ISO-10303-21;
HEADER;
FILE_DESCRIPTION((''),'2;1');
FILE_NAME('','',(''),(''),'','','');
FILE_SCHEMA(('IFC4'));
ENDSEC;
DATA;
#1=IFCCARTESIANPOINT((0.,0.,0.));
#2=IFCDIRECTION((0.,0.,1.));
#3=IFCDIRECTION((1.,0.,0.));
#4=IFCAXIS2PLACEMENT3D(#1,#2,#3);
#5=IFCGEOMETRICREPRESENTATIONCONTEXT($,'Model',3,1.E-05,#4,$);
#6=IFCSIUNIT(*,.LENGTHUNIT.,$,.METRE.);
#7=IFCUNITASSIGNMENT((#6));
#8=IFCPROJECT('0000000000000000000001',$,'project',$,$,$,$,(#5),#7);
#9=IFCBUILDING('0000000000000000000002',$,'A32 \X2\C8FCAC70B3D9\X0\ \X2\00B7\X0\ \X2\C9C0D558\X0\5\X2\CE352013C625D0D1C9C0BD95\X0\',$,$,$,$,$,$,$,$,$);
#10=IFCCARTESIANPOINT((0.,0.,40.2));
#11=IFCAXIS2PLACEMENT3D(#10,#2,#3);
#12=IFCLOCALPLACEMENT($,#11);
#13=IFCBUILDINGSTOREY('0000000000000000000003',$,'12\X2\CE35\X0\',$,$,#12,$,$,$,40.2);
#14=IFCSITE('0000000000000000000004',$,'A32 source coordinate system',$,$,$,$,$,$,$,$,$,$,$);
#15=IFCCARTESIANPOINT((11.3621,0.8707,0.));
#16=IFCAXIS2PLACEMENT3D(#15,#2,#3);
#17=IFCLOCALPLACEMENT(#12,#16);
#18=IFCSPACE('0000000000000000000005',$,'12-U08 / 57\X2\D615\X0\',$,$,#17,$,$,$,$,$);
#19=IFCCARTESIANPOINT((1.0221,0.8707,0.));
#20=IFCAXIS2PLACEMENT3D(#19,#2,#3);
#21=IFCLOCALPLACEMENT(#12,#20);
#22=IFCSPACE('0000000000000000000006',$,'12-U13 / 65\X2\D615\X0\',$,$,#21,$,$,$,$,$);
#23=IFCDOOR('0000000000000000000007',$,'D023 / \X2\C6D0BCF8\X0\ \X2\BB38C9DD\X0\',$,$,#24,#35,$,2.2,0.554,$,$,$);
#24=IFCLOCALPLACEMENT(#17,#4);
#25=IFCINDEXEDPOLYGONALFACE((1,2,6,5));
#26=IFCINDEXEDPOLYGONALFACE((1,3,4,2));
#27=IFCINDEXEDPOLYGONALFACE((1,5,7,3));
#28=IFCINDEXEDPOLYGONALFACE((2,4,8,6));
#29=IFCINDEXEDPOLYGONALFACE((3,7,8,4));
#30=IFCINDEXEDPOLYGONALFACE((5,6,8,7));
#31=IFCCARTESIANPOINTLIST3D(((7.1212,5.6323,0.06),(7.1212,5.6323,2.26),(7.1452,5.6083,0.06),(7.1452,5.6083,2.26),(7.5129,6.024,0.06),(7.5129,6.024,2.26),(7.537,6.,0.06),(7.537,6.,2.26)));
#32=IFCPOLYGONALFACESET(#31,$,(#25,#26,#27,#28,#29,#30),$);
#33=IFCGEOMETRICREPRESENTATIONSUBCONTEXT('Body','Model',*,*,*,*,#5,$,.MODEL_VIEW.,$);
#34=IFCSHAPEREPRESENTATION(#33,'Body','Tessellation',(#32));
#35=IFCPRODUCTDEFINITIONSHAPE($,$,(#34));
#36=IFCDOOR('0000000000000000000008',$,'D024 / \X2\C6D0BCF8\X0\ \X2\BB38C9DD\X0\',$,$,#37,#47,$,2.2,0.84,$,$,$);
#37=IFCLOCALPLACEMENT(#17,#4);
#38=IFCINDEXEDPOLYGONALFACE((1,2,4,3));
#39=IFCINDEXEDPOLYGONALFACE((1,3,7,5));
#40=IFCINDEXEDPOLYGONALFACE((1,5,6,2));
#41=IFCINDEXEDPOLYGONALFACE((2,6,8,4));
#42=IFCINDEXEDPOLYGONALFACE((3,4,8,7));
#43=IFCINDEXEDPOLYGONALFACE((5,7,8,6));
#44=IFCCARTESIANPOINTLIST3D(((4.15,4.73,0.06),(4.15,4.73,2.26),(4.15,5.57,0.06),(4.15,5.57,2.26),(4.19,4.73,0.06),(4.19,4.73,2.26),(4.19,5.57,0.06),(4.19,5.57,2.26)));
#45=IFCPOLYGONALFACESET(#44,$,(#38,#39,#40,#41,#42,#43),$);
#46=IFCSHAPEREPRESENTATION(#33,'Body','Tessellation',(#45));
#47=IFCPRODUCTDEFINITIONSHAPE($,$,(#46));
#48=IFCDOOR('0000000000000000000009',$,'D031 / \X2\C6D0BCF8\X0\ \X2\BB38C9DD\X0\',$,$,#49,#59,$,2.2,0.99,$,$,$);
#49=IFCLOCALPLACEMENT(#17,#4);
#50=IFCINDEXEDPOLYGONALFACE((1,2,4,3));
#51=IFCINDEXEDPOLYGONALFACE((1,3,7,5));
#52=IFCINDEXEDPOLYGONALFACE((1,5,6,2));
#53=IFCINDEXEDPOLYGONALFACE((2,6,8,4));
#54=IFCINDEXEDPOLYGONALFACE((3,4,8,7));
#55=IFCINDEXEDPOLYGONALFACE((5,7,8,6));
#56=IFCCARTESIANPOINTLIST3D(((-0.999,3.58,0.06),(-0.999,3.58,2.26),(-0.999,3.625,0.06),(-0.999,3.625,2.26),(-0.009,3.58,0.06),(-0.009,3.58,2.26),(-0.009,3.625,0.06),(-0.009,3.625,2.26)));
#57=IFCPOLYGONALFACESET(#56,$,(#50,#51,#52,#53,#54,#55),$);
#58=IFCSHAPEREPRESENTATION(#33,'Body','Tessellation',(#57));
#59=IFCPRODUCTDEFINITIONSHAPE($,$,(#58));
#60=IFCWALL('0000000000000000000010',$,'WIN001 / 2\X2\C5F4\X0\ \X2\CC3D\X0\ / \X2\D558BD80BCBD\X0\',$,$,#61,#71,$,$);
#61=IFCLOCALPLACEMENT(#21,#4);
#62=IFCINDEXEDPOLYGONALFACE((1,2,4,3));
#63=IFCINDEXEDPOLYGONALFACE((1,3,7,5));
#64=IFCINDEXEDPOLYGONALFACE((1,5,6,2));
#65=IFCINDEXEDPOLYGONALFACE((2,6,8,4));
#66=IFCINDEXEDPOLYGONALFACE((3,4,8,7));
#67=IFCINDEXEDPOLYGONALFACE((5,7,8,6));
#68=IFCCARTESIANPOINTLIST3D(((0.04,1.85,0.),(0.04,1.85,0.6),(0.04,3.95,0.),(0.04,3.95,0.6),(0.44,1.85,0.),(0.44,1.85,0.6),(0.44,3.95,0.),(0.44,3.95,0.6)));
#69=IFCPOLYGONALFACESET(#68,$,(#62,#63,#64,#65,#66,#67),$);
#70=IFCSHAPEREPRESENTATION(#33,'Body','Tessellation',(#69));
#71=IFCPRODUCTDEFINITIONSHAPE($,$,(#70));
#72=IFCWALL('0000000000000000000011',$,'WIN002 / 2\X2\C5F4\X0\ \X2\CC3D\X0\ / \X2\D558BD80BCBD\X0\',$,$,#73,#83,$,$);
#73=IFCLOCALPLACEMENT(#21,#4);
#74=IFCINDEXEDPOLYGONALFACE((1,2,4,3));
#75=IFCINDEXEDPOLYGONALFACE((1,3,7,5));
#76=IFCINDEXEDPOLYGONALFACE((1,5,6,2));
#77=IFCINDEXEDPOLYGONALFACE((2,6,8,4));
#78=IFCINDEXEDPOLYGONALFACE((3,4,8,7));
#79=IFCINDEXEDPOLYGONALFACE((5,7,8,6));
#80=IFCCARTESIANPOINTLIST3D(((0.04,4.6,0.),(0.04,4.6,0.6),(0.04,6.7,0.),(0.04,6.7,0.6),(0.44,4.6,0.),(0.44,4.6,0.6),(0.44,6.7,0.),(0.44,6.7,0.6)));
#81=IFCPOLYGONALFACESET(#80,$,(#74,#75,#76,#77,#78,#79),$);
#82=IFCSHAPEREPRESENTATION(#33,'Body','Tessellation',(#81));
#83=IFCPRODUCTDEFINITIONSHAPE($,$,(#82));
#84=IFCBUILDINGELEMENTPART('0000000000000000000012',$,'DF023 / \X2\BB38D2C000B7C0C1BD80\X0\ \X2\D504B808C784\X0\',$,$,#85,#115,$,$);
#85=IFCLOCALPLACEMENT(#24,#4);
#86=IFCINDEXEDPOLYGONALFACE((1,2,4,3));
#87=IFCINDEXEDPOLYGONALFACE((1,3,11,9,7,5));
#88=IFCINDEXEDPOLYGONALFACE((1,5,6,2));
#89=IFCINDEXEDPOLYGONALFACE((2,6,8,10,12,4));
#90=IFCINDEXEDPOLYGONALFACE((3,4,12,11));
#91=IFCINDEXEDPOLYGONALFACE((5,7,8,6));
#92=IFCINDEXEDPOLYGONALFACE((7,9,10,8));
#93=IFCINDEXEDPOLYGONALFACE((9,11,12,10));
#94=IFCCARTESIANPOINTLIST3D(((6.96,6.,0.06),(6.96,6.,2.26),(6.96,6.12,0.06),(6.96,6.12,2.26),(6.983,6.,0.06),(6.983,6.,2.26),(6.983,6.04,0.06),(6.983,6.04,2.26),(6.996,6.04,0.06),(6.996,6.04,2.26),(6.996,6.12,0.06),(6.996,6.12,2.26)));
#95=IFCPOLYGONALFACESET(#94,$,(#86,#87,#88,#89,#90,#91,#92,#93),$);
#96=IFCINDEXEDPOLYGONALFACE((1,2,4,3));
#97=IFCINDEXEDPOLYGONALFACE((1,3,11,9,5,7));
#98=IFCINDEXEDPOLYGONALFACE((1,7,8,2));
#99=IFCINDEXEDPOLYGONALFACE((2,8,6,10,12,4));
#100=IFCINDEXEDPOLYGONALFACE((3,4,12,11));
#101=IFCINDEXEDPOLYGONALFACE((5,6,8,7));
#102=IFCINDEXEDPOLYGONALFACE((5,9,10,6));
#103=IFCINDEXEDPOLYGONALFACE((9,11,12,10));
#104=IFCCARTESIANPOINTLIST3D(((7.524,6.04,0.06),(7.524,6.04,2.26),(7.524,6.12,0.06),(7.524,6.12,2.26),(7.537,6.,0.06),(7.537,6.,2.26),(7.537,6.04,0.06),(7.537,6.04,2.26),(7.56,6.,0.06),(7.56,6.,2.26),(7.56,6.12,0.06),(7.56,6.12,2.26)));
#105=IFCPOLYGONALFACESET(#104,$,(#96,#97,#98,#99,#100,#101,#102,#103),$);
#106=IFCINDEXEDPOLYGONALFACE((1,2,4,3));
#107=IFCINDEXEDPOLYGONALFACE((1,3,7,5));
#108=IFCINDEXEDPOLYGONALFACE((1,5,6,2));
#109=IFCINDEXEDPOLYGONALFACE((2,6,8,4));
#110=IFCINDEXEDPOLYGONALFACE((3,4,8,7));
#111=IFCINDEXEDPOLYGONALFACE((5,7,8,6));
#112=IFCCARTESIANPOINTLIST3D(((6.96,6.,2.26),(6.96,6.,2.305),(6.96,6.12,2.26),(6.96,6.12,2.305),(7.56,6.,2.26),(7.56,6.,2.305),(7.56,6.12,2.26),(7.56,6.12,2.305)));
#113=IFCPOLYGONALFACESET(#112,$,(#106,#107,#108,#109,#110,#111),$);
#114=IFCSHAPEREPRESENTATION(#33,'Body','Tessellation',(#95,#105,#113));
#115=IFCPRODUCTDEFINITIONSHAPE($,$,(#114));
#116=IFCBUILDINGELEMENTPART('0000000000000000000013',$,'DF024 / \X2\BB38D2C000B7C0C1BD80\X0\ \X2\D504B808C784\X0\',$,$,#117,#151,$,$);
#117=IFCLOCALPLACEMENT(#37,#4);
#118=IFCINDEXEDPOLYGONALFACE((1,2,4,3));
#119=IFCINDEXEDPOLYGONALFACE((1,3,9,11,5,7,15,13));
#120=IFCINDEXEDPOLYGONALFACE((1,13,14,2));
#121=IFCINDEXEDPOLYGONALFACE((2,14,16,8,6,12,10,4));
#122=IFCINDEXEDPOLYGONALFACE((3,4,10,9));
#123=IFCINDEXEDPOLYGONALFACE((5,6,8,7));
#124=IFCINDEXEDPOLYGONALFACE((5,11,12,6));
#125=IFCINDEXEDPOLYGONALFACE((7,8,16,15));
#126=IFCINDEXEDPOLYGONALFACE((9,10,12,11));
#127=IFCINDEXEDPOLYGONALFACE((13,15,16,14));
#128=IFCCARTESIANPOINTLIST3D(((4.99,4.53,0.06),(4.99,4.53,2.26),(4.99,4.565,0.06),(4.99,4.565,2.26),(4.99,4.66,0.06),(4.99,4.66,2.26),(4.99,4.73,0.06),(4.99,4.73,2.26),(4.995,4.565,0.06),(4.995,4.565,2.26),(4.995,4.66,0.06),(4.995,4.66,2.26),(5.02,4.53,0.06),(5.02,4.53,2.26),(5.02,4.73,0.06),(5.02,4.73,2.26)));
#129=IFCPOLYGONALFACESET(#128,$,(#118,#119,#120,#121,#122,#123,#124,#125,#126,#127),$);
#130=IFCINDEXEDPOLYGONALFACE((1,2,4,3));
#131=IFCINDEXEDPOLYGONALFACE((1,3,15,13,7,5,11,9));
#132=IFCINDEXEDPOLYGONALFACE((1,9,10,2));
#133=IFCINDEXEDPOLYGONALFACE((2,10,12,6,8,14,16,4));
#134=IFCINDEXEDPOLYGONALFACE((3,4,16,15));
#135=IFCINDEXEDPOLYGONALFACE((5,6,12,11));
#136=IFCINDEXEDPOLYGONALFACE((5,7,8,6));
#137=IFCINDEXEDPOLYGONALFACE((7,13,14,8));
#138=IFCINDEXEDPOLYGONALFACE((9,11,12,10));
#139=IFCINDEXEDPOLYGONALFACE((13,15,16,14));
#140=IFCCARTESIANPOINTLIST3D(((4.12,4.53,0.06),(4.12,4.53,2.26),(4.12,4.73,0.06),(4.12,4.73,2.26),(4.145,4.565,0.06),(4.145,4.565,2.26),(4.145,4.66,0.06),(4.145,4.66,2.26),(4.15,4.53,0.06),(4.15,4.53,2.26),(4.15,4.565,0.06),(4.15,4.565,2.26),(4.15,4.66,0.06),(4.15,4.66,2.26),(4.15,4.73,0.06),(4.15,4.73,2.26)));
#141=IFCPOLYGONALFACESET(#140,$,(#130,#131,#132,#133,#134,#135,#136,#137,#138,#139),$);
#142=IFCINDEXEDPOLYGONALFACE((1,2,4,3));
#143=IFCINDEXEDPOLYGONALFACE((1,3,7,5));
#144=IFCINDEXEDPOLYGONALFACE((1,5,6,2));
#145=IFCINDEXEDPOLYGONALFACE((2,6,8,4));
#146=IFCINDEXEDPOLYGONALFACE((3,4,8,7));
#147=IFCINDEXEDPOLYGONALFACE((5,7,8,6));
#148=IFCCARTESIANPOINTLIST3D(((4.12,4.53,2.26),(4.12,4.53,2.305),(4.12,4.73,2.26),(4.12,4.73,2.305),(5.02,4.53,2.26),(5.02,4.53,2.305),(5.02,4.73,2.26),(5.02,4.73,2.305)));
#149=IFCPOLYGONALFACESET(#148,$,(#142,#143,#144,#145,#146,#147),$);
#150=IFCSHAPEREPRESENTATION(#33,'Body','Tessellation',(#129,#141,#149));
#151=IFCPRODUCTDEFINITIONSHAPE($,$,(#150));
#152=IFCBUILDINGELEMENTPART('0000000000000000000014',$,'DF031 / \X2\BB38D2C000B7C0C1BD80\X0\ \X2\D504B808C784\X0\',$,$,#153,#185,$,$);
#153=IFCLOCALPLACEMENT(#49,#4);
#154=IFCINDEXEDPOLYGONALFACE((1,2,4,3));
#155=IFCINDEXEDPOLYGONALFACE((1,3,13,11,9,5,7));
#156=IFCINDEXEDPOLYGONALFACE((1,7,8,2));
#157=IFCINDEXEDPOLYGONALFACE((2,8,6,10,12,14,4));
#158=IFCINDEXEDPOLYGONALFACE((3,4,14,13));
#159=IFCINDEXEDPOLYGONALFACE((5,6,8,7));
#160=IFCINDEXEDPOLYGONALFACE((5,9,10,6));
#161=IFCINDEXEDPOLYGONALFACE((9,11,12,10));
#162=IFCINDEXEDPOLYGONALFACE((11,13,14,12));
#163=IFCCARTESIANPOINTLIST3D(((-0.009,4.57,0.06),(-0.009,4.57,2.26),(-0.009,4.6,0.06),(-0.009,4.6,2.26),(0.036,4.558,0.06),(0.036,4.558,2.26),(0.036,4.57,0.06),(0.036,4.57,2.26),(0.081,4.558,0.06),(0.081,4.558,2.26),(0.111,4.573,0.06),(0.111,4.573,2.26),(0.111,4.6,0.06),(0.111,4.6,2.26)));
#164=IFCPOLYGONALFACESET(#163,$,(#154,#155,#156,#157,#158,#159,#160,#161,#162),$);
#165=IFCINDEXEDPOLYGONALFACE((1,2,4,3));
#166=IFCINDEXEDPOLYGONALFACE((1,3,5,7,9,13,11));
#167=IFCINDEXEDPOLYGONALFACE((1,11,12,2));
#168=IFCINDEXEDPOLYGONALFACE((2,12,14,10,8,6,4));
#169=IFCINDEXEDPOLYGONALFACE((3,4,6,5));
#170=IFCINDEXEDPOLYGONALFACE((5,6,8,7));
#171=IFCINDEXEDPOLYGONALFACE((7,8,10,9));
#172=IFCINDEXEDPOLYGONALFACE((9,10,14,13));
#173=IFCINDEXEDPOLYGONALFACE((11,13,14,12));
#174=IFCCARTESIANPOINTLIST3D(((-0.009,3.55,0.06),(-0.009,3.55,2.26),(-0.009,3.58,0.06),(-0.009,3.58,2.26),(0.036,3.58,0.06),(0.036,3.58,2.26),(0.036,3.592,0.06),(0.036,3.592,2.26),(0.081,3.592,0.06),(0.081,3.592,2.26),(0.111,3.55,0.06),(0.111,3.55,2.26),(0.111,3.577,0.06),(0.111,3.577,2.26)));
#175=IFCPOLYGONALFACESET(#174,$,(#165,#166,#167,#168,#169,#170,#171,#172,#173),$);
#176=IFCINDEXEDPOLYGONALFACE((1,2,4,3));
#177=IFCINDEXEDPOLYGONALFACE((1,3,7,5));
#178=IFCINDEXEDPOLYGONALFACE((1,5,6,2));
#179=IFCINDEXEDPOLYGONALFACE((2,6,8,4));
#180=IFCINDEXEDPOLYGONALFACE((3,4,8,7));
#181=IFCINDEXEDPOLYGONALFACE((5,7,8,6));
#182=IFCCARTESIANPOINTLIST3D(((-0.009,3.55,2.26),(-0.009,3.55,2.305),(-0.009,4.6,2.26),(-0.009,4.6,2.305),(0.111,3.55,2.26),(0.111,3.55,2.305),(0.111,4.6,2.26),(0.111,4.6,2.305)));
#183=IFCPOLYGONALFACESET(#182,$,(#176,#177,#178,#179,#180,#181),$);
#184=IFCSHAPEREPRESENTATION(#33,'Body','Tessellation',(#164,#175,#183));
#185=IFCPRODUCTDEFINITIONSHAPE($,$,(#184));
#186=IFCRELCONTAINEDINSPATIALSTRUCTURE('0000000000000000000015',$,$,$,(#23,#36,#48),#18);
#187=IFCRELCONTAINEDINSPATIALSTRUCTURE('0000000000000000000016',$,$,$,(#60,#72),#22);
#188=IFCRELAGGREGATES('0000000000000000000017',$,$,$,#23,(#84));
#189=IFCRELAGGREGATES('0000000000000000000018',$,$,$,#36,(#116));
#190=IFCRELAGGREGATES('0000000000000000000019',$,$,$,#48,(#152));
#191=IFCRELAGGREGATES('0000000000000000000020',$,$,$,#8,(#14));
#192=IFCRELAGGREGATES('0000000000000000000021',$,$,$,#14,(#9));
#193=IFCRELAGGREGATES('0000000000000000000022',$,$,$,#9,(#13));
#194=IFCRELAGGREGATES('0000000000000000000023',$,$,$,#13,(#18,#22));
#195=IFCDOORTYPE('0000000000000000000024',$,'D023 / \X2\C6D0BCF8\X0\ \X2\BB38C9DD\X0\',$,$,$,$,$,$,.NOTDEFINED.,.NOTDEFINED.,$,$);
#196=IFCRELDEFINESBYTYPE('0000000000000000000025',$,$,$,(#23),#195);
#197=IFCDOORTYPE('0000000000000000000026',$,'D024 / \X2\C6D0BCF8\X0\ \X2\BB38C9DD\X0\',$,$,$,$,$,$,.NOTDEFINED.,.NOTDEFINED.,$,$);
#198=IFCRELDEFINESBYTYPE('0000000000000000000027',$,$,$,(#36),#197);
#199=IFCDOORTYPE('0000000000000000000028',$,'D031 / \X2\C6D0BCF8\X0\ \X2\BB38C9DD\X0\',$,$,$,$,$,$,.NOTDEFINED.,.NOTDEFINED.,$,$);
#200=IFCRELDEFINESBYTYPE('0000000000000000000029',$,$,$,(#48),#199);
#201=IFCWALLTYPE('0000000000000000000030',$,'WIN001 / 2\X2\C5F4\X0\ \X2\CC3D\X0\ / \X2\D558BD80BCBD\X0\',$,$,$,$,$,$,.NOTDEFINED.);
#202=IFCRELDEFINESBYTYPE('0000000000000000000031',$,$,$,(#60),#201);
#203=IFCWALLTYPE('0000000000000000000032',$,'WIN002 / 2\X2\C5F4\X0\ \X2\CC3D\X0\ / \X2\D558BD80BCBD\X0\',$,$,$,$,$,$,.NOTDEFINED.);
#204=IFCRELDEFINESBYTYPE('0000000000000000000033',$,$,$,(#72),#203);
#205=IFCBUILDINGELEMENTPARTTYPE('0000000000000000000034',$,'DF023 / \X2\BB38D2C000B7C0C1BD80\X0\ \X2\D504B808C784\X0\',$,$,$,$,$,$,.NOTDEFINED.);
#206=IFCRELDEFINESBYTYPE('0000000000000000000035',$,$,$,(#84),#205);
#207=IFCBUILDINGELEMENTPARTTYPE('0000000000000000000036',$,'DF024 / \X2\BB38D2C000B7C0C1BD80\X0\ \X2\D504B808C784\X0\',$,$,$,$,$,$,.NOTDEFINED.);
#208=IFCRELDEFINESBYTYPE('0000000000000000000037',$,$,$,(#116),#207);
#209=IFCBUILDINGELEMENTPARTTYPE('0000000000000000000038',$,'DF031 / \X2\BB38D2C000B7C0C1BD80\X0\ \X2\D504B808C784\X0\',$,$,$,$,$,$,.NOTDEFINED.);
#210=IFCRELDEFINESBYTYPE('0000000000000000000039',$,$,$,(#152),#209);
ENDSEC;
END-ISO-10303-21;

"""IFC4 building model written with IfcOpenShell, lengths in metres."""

from ifc_helpers import new_model, si_unit, frame, origin, origin_with_axes, place, context, subcontext, project, spatial, polyline, outline, extrude, source, transform, mapped, type_object, type_shapes, element, aggregate, save


model = new_model("IFC4")

# Units and contexts
model_context = context("Model", 3, precision=1e-05, world=origin_with_axes())
body_context = subcontext(model_context, "Body", "Model", "MODEL_VIEW")
ifc_project = project(units=[si_unit("LENGTHUNIT", "METRE")], contexts=[model_context])

# Site, building, storey, space
site = spatial("IfcSite", under=ifc_project, Name="A32 source coordinate system")
building = spatial("IfcBuilding", under=site, Name="A32 주거동 · 지하5층–옥탑지붕")
storey_placement = place(None, frame((0.0, 0.0, 40.2), z_axis=(0.0, 0.0, 1.0), x_axis=(1.0, 0.0, 0.0)))
storey = spatial("IfcBuildingStorey", under=building, at=storey_placement, Name="12층", Elevation=40.2)
space_1_placement = place(storey_placement, frame((11.3621, 0.8707, 0.0), z_axis=(0.0, 0.0, 1.0), x_axis=(1.0, 0.0, 0.0)))
space_1 = spatial("IfcSpace", under=storey, at=space_1_placement, Name="12-U08 / 57형")

# Doors
door_type_1 = type_object("IfcDoorType", Name="D023 / 원본 문짝", OperationType="NOTDEFINED", PredefinedType="NOTDEFINED")
shared_shape_1 = source(origin(), body_context, "Body", "SweptSolid", [
    extrude(outline(polyline([(7.537, 6.0), (7.1452, 5.6083), (7.1212, 5.6323), (7.5129, 6.024), (7.537, 6.0)])), frame((0.0, 0.0, 0.06)), (0.0, 0.0, 1.0), 2.2),
])
type_shapes(door_type_1, [shared_shape_1])
door_1_placement = place(space_1_placement, origin_with_axes())
door_1 = element("IfcDoor", 1, at=door_1_placement, inside=space_1, type_object=door_type_1, Name="D023 / 원본 문짝", OverallHeight=2.2, OverallWidth=0.554, context=body_context, shape_type="MappedRepresentation", body=[
    mapped(shared_shape_1, transform((0.0, 0.0, 0.0), scale=1.0)),
])
door_type_2 = type_object("IfcDoorType", Name="D024 / 원본 문짝", OperationType="NOTDEFINED", PredefinedType="NOTDEFINED")
shared_shape_2 = source(origin(), body_context, "Body", "SweptSolid", [
    extrude(outline(polyline([(4.15, 4.73), (4.15, 5.57), (4.19, 5.57), (4.19, 4.73), (4.15, 4.73)])), frame((0.0, 0.0, 0.06)), (0.0, 0.0, 1.0), 2.2),
])
type_shapes(door_type_2, [shared_shape_2])
door_2_placement = place(space_1_placement, origin_with_axes())
door_2 = element("IfcDoor", 2, at=door_2_placement, inside=space_1, type_object=door_type_2, Name="D024 / 원본 문짝", OverallHeight=2.2, OverallWidth=0.84, context=body_context, shape_type="MappedRepresentation", body=[
    mapped(shared_shape_2, transform((0.0, 0.0, 0.0), scale=1.0)),
])
door_type_3 = type_object("IfcDoorType", Name="D031 / 원본 문짝", OperationType="NOTDEFINED", PredefinedType="NOTDEFINED")
shared_shape_3 = source(origin(), body_context, "Body", "SweptSolid", [
    extrude(outline(polyline([(-0.009, 3.58), (-0.999, 3.58), (-0.999, 3.625), (-0.009, 3.625), (-0.009, 3.58)])), frame((0.0, 0.0, 0.06)), (0.0, 0.0, 1.0), 2.2),
])
type_shapes(door_type_3, [shared_shape_3])
door_3_placement = place(space_1_placement, origin_with_axes())
door_3 = element("IfcDoor", 3, at=door_3_placement, inside=space_1, type_object=door_type_3, Name="D031 / 원본 문짝", OverallHeight=2.2, OverallWidth=0.99, context=body_context, shape_type="MappedRepresentation", body=[
    mapped(shared_shape_3, transform((0.0, 0.0, 0.0), scale=1.0)),
])

# Shared definitions
space_2_placement = place(storey_placement, frame((1.0221, 0.8707, 0.0), z_axis=(0.0, 0.0, 1.0), x_axis=(1.0, 0.0, 0.0)))
space_2 = spatial("IfcSpace", under=storey, at=space_2_placement, Name="12-U13 / 65형")

# Walls
wall_type_1 = type_object("IfcWallType", Name="WIN001 / 2열 창 / 하부벽", PredefinedType="NOTDEFINED")
shared_shape_4 = source(origin(), body_context, "Body", "SweptSolid", [
    extrude(outline(polyline([(0.04, 3.95), (0.44, 3.95), (0.44, 1.85), (0.04, 1.85), (0.04, 3.95)])), origin(), (0.0, 0.0, 1.0), 0.6),
])
type_shapes(wall_type_1, [shared_shape_4])
wall_1_placement = place(space_2_placement, origin_with_axes())
element("IfcWall", 4, at=wall_1_placement, inside=space_2, type_object=wall_type_1, Name="WIN001 / 2열 창 / 하부벽", context=body_context, shape_type="MappedRepresentation", body=[
    mapped(shared_shape_4, transform((0.0, 0.0, 0.0), scale=1.0)),
])
wall_type_2 = type_object("IfcWallType", Name="WIN002 / 2열 창 / 하부벽", PredefinedType="NOTDEFINED")
shared_shape_5 = source(origin(), body_context, "Body", "SweptSolid", [
    extrude(outline(polyline([(0.04, 6.7), (0.44, 6.7), (0.44, 4.6), (0.04, 4.6), (0.04, 6.7)])), origin(), (0.0, 0.0, 1.0), 0.6),
])
type_shapes(wall_type_2, [shared_shape_5])
wall_2_placement = place(space_2_placement, origin_with_axes())
element("IfcWall", 5, at=wall_2_placement, inside=space_2, type_object=wall_type_2, Name="WIN002 / 2열 창 / 하부벽", context=body_context, shape_type="MappedRepresentation", body=[
    mapped(shared_shape_5, transform((0.0, 0.0, 0.0), scale=1.0)),
])

# Building element parts
building_element_part_type_1 = type_object("IfcBuildingElementPartType", Name="DF023 / 문틀·상부 프레임", PredefinedType="NOTDEFINED")
shared_shape_6 = source(origin(), body_context, "Body", "SweptSolid", [
    extrude(outline(polyline([(6.996, 6.12), (6.996, 6.04), (6.983, 6.04), (6.983, 6.0), (6.96, 6.0), (6.96, 6.12), (6.996, 6.12)])), frame((0.0, 0.0, 0.06)), (0.0, 0.0, 1.0), 2.2),
    extrude(outline(polyline([(7.56, 6.0), (7.537, 6.0), (7.537, 6.04), (7.524, 6.04), (7.524, 6.12), (7.56, 6.12), (7.56, 6.0)])), frame((0.0, 0.0, 0.06)), (0.0, 0.0, 1.0), 2.2),
    extrude(outline(polyline([(6.96, 6.0), (6.96, 6.12), (7.56, 6.12), (7.56, 6.0), (6.96, 6.0)])), frame((0.0, 0.0, 2.26)), (0.0, 0.0, 1.0), 0.045),
])
type_shapes(building_element_part_type_1, [shared_shape_6])
building_element_part_1_placement = place(door_1_placement, origin_with_axes())
building_element_part_1 = element("IfcBuildingElementPart", 6, at=building_element_part_1_placement, type_object=building_element_part_type_1, Name="DF023 / 문틀·상부 프레임", context=body_context, shape_type="MappedRepresentation", body=[
    mapped(shared_shape_6, transform((0.0, 0.0, 0.0), scale=1.0)),
])
aggregate(door_1, [building_element_part_1])
building_element_part_type_2 = type_object("IfcBuildingElementPartType", Name="DF024 / 문틀·상부 프레임", PredefinedType="NOTDEFINED")
shared_shape_7 = source(origin(), body_context, "Body", "SweptSolid", [
    extrude(outline(polyline([(5.02, 4.53), (4.99, 4.53), (4.99, 4.565), (4.995, 4.565), (4.995, 4.66), (4.99, 4.66), (4.99, 4.73), (5.02, 4.73), (5.02, 4.53)])), frame((0.0, 0.0, 0.06)), (0.0, 0.0, 1.0), 2.2),
    extrude(outline(polyline([(4.15, 4.73), (4.15, 4.66), (4.145, 4.66), (4.145, 4.565), (4.15, 4.565), (4.15, 4.53), (4.12, 4.53), (4.12, 4.73), (4.15, 4.73)])), frame((0.0, 0.0, 0.06)), (0.0, 0.0, 1.0), 2.2),
    extrude(outline(polyline([(4.12, 4.53), (4.12, 4.73), (5.02, 4.73), (5.02, 4.53), (4.12, 4.53)])), frame((0.0, 0.0, 2.26)), (0.0, 0.0, 1.0), 0.045),
])
type_shapes(building_element_part_type_2, [shared_shape_7])
building_element_part_2_placement = place(door_2_placement, origin_with_axes())
building_element_part_2 = element("IfcBuildingElementPart", 7, at=building_element_part_2_placement, type_object=building_element_part_type_2, Name="DF024 / 문틀·상부 프레임", context=body_context, shape_type="MappedRepresentation", body=[
    mapped(shared_shape_7, transform((0.0, 0.0, 0.0), scale=1.0)),
])
aggregate(door_2, [building_element_part_2])
building_element_part_type_3 = type_object("IfcBuildingElementPartType", Name="DF031 / 문틀·상부 프레임", PredefinedType="NOTDEFINED")
shared_shape_8 = source(origin(), body_context, "Body", "SweptSolid", [
    extrude(outline(polyline([(0.111, 4.6), (0.111, 4.573), (0.081, 4.558), (0.036, 4.558), (0.036, 4.57), (-0.009, 4.57), (-0.009, 4.6), (0.111, 4.6)])), frame((0.0, 0.0, 0.06)), (0.0, 0.0, 1.0), 2.2),
    extrude(outline(polyline([(-0.009, 3.58), (0.036, 3.58), (0.036, 3.592), (0.081, 3.592), (0.111, 3.577), (0.111, 3.55), (-0.009, 3.55), (-0.009, 3.58)])), frame((0.0, 0.0, 0.06)), (0.0, 0.0, 1.0), 2.2),
    extrude(outline(polyline([(-0.009, 3.55), (-0.009, 4.6), (0.111, 4.6), (0.111, 3.55), (-0.009, 3.55)])), frame((0.0, 0.0, 2.26)), (0.0, 0.0, 1.0), 0.045),
])
type_shapes(building_element_part_type_3, [shared_shape_8])
building_element_part_3_placement = place(door_3_placement, origin_with_axes())
building_element_part_3 = element("IfcBuildingElementPart", 8, at=building_element_part_3_placement, type_object=building_element_part_type_3, Name="DF031 / 문틀·상부 프레임", context=body_context, shape_type="MappedRepresentation", body=[
    mapped(shared_shape_8, transform((0.0, 0.0, 0.0), scale=1.0)),
])
aggregate(door_3, [building_element_part_3])

save(model, "model.ifc")
